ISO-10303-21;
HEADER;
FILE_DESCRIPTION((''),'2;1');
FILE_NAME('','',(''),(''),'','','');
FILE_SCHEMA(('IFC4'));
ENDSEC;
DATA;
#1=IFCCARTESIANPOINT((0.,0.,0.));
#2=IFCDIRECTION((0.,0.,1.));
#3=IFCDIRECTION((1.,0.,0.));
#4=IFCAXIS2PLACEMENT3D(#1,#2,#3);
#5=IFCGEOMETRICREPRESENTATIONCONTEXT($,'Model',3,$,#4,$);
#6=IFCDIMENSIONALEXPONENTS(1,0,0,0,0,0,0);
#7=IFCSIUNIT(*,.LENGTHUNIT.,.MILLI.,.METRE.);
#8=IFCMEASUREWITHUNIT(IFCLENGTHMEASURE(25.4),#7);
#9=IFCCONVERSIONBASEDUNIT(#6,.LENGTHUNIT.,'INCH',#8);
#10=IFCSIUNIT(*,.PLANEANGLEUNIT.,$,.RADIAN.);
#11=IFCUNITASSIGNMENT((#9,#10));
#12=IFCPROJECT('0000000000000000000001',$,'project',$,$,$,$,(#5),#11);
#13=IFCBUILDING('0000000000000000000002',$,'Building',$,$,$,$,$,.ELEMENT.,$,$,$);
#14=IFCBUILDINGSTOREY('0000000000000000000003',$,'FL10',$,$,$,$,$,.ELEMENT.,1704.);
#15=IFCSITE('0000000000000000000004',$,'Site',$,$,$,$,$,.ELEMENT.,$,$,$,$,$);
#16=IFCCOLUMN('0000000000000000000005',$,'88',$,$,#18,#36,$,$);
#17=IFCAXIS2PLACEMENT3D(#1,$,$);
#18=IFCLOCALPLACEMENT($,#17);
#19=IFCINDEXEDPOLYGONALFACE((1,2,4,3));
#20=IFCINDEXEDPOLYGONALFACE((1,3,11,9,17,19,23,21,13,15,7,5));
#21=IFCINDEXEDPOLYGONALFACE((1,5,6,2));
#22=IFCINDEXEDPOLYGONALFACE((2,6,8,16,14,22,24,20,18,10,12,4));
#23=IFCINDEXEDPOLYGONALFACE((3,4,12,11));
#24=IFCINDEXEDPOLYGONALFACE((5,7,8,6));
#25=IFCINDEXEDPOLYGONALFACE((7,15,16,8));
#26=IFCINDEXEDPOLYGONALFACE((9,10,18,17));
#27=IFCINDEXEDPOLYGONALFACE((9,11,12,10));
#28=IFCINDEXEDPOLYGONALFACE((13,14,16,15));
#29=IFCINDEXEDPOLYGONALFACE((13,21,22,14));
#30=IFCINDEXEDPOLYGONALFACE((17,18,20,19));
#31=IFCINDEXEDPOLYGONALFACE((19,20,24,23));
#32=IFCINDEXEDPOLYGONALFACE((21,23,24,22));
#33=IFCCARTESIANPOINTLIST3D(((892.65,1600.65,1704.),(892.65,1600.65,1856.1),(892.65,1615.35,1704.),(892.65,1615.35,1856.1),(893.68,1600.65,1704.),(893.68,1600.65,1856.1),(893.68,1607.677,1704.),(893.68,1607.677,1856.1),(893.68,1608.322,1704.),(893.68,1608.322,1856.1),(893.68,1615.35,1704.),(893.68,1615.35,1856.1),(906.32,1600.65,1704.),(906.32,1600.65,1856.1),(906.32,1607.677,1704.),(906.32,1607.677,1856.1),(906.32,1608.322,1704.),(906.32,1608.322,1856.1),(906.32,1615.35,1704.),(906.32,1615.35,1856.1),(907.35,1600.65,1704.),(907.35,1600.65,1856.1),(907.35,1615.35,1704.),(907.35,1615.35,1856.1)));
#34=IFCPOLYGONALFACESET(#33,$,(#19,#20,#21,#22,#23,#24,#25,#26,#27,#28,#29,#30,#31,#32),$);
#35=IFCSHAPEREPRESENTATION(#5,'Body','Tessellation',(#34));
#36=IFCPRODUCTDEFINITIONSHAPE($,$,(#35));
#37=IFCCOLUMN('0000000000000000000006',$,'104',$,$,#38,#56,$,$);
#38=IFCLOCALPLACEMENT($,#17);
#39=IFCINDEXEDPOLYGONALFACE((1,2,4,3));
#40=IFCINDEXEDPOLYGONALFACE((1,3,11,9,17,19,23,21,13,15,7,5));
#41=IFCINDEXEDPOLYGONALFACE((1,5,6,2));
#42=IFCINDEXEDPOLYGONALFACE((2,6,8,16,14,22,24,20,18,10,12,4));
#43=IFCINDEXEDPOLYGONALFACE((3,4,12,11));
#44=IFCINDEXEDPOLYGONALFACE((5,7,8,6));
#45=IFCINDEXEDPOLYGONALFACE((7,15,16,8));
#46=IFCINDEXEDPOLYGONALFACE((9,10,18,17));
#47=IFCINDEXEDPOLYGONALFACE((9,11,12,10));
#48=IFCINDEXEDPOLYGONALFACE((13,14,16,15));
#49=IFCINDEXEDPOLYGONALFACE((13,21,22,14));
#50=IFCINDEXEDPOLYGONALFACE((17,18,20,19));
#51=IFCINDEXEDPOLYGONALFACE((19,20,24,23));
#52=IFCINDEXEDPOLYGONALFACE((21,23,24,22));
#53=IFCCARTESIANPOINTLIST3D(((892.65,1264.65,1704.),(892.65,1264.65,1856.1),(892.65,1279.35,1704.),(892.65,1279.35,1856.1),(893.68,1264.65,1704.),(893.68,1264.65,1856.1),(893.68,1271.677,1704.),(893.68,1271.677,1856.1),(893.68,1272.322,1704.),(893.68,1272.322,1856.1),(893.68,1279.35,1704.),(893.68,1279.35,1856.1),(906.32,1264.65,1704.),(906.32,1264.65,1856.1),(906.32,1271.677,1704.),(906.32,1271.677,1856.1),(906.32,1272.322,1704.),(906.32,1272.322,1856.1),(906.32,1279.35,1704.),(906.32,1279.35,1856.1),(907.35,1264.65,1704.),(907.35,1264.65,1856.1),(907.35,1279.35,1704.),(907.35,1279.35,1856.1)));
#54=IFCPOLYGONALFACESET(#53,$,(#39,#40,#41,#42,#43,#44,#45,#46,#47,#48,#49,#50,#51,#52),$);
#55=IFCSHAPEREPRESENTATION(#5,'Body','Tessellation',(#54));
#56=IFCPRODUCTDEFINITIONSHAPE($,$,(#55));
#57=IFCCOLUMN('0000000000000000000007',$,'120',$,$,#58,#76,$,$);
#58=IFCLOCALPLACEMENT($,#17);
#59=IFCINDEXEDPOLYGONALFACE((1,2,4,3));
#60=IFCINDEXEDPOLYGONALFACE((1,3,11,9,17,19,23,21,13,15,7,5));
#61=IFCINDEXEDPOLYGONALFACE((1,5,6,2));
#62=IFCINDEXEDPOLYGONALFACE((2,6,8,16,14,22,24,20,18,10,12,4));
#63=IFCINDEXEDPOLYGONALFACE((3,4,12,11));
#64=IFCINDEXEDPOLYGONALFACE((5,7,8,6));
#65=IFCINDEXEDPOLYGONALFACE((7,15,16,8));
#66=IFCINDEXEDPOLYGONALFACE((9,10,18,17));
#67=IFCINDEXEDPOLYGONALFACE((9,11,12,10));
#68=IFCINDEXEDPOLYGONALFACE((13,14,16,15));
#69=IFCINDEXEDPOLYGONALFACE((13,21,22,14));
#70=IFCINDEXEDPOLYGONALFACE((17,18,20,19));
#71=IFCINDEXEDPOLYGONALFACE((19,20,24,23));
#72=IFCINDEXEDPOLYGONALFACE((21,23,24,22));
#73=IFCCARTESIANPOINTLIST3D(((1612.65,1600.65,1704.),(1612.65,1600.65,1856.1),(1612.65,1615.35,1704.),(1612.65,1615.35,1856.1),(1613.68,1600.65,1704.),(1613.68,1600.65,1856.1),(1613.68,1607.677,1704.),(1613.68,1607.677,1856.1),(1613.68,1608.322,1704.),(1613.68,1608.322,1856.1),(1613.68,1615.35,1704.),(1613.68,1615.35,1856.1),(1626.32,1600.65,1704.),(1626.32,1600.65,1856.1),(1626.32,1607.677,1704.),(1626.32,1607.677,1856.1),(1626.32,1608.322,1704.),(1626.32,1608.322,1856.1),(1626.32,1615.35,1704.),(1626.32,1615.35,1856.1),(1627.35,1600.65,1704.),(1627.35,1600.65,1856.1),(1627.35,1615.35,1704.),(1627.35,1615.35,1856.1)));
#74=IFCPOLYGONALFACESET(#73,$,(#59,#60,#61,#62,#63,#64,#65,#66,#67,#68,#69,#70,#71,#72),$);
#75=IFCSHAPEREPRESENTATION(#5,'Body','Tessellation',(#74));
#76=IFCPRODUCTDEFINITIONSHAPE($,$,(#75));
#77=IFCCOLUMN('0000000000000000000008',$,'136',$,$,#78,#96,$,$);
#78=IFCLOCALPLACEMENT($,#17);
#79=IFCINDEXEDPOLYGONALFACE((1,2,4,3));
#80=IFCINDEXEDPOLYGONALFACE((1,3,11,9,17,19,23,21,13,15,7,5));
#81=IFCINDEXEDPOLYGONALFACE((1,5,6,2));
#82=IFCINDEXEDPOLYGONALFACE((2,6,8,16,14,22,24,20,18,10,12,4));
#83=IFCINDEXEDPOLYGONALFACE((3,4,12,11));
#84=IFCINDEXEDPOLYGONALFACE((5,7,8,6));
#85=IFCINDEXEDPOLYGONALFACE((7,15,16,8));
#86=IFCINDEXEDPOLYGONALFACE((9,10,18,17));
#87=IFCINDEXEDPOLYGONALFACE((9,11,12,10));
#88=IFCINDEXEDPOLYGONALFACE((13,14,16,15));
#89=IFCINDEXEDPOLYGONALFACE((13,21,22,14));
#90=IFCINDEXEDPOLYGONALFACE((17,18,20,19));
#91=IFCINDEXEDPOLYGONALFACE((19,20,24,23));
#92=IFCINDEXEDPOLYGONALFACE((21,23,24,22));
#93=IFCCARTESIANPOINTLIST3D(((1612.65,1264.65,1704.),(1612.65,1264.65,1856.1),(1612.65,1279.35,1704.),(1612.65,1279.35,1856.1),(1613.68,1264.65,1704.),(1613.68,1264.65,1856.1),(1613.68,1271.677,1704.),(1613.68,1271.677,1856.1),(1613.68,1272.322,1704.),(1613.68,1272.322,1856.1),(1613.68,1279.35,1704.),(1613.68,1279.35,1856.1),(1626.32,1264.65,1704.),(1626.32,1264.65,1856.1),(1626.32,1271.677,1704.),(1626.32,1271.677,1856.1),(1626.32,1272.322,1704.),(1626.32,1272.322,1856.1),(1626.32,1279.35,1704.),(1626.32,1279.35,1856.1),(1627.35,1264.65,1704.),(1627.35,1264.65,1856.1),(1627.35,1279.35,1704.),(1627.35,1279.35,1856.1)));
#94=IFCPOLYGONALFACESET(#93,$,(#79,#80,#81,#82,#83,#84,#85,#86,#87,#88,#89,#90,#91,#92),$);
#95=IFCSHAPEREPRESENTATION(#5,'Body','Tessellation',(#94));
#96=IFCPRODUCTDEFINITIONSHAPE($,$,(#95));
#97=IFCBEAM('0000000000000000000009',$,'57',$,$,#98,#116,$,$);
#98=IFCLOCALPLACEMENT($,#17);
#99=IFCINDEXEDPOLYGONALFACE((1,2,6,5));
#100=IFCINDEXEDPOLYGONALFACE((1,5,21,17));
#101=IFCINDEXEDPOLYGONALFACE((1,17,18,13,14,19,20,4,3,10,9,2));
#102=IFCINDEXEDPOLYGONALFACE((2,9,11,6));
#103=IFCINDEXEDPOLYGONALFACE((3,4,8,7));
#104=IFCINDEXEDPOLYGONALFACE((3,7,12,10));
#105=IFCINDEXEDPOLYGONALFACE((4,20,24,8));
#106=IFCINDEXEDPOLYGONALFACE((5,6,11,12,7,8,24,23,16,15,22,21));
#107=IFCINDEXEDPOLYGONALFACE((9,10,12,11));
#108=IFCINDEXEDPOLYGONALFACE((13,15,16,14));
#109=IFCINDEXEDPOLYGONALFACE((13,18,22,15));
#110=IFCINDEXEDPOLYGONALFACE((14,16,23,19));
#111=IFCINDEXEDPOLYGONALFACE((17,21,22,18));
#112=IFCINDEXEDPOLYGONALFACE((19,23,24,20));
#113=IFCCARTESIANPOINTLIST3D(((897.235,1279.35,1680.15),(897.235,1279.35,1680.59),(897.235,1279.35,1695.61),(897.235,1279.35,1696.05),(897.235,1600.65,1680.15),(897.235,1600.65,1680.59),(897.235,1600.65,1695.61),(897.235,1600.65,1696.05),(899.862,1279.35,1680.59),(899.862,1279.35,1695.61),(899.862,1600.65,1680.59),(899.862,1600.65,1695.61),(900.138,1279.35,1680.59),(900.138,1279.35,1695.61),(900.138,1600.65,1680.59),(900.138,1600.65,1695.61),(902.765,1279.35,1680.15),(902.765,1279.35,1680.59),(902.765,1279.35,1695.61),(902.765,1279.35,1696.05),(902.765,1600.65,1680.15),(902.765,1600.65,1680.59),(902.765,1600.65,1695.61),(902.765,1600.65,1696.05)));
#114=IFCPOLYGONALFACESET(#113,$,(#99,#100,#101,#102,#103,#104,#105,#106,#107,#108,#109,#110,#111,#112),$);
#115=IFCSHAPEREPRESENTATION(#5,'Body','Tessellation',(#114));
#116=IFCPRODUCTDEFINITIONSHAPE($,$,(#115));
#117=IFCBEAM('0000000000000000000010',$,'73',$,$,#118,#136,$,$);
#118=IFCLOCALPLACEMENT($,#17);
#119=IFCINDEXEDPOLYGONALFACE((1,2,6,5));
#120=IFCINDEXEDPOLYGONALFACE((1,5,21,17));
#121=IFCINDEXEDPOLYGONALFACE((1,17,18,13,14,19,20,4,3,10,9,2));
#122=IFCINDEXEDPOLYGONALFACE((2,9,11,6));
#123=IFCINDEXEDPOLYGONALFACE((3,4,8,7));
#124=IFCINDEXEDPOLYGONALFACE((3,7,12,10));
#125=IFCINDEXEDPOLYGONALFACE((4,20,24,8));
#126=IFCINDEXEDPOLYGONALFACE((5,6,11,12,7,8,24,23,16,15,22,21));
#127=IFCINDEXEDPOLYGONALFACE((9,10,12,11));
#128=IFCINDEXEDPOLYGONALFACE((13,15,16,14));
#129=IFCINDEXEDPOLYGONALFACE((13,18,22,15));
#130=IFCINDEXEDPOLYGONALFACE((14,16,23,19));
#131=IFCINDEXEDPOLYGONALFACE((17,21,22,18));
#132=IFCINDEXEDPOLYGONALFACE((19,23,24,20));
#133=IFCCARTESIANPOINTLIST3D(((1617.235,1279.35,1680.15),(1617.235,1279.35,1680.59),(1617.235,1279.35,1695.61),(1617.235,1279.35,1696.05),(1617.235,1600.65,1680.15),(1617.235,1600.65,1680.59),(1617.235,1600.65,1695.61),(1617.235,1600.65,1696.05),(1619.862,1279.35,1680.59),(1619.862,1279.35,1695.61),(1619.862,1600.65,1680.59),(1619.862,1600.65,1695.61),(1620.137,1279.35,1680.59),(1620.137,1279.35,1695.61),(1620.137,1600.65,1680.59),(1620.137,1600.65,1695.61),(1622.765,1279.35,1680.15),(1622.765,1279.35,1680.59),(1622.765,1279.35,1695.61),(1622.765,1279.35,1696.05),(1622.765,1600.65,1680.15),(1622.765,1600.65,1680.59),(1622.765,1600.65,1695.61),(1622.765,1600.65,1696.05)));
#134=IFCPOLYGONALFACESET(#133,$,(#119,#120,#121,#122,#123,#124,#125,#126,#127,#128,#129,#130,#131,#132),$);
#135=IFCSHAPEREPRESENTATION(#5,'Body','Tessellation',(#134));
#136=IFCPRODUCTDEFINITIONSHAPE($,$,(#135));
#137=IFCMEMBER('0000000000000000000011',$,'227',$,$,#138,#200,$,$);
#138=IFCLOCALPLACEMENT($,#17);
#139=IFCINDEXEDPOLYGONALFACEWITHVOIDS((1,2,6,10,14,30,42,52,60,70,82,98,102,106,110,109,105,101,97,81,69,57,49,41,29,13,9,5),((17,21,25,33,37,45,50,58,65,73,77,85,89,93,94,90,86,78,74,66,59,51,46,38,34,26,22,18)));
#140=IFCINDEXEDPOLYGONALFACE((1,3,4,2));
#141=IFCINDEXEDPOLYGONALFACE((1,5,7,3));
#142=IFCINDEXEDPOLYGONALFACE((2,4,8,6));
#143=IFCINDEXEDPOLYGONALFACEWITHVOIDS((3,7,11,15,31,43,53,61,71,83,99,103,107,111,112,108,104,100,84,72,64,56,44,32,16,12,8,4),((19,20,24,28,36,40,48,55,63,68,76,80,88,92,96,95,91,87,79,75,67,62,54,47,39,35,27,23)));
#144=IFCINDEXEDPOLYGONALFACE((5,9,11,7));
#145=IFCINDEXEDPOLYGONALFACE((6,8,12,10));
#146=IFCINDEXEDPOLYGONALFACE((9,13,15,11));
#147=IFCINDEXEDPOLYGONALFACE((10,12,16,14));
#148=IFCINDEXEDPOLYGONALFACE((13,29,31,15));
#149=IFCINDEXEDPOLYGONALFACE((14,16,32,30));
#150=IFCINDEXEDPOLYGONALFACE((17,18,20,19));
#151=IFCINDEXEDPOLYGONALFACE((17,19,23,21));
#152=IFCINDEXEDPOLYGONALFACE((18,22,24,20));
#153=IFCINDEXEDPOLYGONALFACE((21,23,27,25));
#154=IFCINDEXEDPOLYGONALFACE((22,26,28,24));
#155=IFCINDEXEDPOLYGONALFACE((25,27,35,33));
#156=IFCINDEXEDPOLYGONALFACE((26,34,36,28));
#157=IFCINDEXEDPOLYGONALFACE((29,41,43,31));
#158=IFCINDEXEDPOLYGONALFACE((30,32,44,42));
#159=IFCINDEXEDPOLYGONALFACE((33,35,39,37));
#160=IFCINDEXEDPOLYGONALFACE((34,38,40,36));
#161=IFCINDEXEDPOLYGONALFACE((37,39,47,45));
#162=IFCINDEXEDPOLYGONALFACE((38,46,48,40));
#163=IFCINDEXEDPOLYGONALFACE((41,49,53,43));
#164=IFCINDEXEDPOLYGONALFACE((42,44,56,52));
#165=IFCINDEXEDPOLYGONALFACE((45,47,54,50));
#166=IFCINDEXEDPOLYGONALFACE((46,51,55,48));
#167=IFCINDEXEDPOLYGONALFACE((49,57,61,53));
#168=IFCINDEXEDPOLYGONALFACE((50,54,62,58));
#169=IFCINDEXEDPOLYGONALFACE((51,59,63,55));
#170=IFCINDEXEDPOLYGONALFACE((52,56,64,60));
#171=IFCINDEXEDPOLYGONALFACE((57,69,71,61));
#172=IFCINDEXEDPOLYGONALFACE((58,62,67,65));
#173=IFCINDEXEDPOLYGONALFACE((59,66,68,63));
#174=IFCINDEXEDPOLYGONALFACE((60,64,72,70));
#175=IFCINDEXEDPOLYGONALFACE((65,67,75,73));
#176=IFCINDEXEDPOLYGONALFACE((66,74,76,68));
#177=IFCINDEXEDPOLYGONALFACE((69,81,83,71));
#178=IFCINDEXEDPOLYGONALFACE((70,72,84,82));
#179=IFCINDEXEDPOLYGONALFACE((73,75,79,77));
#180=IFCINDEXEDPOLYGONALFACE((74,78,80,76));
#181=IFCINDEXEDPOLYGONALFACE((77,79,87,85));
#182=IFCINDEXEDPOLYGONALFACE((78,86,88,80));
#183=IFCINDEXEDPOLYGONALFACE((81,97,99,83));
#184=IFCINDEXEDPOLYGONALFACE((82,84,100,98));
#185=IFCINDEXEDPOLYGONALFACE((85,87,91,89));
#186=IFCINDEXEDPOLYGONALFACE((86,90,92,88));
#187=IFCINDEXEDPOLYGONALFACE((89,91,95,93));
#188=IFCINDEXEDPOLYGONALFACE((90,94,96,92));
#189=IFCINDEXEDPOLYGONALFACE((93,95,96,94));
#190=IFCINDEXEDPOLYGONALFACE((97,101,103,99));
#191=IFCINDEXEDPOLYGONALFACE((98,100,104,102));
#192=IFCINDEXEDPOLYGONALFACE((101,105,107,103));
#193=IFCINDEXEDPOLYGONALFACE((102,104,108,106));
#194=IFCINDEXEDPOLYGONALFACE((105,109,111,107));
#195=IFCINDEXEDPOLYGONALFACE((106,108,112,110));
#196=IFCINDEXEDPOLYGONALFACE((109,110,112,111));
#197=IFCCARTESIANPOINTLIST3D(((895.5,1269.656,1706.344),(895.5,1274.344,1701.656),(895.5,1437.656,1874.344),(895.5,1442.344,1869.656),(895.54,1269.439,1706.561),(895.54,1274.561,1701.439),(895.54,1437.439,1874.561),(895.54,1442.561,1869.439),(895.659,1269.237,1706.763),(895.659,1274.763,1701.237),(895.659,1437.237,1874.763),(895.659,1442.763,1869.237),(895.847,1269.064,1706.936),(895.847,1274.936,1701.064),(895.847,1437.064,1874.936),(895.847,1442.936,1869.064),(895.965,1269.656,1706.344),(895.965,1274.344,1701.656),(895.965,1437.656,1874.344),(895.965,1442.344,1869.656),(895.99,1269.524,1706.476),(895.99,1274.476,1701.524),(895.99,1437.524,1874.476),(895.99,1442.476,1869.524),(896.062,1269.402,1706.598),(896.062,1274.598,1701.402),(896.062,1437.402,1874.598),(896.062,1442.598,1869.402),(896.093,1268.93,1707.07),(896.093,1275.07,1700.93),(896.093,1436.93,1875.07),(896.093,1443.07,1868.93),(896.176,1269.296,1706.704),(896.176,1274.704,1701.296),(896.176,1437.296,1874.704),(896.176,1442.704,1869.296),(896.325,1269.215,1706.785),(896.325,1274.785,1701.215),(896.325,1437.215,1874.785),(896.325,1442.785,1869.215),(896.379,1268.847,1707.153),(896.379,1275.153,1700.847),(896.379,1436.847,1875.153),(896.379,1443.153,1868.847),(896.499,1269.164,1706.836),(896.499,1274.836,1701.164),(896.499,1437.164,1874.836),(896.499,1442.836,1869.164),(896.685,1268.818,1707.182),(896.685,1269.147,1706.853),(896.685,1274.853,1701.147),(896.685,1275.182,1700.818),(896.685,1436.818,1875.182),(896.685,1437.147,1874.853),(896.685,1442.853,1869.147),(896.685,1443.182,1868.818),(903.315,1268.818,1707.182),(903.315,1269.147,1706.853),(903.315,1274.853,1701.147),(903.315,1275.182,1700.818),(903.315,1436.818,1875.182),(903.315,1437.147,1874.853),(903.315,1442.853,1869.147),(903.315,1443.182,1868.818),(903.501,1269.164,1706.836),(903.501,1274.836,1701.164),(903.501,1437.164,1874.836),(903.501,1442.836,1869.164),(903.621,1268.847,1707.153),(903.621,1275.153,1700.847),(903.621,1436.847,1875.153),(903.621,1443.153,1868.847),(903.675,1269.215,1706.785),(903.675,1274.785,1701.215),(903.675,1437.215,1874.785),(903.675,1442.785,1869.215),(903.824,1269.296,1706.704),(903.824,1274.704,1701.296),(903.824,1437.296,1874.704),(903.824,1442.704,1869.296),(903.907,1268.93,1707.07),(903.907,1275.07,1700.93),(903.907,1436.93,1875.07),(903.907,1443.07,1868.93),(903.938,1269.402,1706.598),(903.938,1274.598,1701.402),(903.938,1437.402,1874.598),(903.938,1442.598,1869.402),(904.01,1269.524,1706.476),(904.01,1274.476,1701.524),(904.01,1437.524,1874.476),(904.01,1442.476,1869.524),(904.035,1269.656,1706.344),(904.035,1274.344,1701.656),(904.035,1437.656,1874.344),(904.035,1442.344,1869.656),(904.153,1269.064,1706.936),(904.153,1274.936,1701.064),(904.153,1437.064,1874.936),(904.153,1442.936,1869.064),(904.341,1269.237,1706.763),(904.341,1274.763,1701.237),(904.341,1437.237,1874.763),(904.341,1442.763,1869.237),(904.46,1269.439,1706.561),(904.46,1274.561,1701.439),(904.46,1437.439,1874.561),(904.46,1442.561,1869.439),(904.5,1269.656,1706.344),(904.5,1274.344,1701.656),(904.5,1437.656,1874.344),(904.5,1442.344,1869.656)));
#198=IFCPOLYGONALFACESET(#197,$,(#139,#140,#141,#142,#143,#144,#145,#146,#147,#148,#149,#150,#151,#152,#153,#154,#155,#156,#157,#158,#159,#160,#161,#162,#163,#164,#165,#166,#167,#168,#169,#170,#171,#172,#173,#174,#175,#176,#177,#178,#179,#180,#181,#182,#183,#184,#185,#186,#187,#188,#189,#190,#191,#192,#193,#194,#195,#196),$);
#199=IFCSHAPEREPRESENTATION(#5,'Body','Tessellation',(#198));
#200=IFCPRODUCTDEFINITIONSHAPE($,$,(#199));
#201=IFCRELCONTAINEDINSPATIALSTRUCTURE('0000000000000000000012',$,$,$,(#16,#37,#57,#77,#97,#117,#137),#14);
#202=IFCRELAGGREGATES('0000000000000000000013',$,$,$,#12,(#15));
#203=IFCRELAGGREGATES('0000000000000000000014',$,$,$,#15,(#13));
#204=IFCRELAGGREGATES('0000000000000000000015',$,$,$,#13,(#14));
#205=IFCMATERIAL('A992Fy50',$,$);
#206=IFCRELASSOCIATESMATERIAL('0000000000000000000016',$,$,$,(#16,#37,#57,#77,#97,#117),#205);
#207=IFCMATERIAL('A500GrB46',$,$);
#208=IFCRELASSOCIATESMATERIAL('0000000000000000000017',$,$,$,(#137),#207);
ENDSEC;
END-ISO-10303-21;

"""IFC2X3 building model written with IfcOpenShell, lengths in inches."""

from ifc_helpers import new_model, entity, si_unit, converted_unit, frame, origin_with_axes, origin_2d_with_axis, place, context, project, spatial, hollow_rectangle, i_section, transform_2d, derived_profile, extrude, material, element, save


model = new_model("IFC2X3")

# Units and contexts
model_context = context("Model", 3, world=origin_with_axes())
ifc_project = project(units=[converted_unit("LENGTHUNIT", "INCH", entity("IfcLengthMeasure", 25.4), si_unit("LENGTHUNIT", "METRE", prefix="MILLI"), dimensions=[1, 0, 0, 0, 0, 0, 0]), si_unit("PLANEANGLEUNIT", "RADIAN")], contexts=[model_context])

# Site, building, storey
site = spatial("IfcSite", under=ifc_project, Name="Site", CompositionType="ELEMENT")
building = spatial("IfcBuilding", under=site, Name="Building", CompositionType="ELEMENT")
storey = spatial("IfcBuildingStorey", under=building, Name="FL10", CompositionType="ELEMENT", Elevation=1704.0)

# Columns
ifc_material_1 = material(Name="A992Fy50")
for number, where, z_axis, x_axis, name in (
    (1, (900.0, 1608.0, 1704.0), (0.0, 0.0, 1.0), (0.0, -1.0, 0.0), "88"),
    (2, (900.0, 1272.0, 1704.0), (0.0, 0.0, 1.0), (0.0, -1.0, 0.0), "104"),
    (3, (1620.0, 1608.0, 1704.0), (0.0, 0.0, 1.0), (0.0, -1.0, 0.0), "120"),
    (4, (1620.0, 1272.0, 1704.0), (0.0, 0.0, 1.0), (0.0, -1.0, 0.0), "136"),
):
    element("IfcColumn", number, at=place(None, frame(where, z_axis=z_axis, x_axis=x_axis)), inside=storey, material=ifc_material_1, Name=name, context=model_context, shape_type="SweptSolid", body=[
        extrude(i_section(OverallWidth=14.7, OverallDepth=14.7, WebThickness=0.645, FlangeThickness=1.03, at=origin_2d_with_axis()), origin_with_axes(), (0.0, 0.0, 1.0), 152.1),
    ])

# Beams
for number, where, z_axis, x_axis, name in (
    (5, (900.0, 1279.35, 1704.0), (0.0, 1.0, 0.0), (-1.0, 0.0, 0.0), "57"),
    (6, (1620.0, 1279.35, 1704.0), (0.0, 1.0, 0.0), (-1.0, 0.0, 0.0), "73"),
):
    element("IfcBeam", number, at=place(None, frame(where, z_axis=z_axis, x_axis=x_axis)), inside=storey, material=ifc_material_1, Name=name, context=model_context, shape_type="SweptSolid", body=[
        extrude(derived_profile(i_section(OverallWidth=5.53, OverallDepth=15.9, WebThickness=0.275, FlangeThickness=0.44, at=origin_2d_with_axis()), transform_2d((0.0, -7.95))), origin_with_axes(), (0.0, 0.0, 1.0), 321.3),
    ])

# Member
ifc_material_2 = material(Name="A500GrB46")
for number, where, z_axis, x_axis, name in (
    (7, (900.0, 1272.0, 1704.0), (0.0, 0.707107, 0.707107), (-1.0, 0.0, 0.0), "227"),
):
    element("IfcMember", number, at=place(None, frame(where, z_axis=z_axis, x_axis=x_axis)), inside=storey, material=ifc_material_2, Name=name, context=model_context, shape_type="SweptSolid", body=[
        extrude(hollow_rectangle(XDim=9.0, YDim=9.0, WallThickness=0.465, InnerFilletRadius=0.72, OuterFilletRadius=1.185, at=origin_2d_with_axis()), origin_with_axes(), (0.0, 0.0, 1.0), 237.588),
    ])

save(model, "model.ifc")
